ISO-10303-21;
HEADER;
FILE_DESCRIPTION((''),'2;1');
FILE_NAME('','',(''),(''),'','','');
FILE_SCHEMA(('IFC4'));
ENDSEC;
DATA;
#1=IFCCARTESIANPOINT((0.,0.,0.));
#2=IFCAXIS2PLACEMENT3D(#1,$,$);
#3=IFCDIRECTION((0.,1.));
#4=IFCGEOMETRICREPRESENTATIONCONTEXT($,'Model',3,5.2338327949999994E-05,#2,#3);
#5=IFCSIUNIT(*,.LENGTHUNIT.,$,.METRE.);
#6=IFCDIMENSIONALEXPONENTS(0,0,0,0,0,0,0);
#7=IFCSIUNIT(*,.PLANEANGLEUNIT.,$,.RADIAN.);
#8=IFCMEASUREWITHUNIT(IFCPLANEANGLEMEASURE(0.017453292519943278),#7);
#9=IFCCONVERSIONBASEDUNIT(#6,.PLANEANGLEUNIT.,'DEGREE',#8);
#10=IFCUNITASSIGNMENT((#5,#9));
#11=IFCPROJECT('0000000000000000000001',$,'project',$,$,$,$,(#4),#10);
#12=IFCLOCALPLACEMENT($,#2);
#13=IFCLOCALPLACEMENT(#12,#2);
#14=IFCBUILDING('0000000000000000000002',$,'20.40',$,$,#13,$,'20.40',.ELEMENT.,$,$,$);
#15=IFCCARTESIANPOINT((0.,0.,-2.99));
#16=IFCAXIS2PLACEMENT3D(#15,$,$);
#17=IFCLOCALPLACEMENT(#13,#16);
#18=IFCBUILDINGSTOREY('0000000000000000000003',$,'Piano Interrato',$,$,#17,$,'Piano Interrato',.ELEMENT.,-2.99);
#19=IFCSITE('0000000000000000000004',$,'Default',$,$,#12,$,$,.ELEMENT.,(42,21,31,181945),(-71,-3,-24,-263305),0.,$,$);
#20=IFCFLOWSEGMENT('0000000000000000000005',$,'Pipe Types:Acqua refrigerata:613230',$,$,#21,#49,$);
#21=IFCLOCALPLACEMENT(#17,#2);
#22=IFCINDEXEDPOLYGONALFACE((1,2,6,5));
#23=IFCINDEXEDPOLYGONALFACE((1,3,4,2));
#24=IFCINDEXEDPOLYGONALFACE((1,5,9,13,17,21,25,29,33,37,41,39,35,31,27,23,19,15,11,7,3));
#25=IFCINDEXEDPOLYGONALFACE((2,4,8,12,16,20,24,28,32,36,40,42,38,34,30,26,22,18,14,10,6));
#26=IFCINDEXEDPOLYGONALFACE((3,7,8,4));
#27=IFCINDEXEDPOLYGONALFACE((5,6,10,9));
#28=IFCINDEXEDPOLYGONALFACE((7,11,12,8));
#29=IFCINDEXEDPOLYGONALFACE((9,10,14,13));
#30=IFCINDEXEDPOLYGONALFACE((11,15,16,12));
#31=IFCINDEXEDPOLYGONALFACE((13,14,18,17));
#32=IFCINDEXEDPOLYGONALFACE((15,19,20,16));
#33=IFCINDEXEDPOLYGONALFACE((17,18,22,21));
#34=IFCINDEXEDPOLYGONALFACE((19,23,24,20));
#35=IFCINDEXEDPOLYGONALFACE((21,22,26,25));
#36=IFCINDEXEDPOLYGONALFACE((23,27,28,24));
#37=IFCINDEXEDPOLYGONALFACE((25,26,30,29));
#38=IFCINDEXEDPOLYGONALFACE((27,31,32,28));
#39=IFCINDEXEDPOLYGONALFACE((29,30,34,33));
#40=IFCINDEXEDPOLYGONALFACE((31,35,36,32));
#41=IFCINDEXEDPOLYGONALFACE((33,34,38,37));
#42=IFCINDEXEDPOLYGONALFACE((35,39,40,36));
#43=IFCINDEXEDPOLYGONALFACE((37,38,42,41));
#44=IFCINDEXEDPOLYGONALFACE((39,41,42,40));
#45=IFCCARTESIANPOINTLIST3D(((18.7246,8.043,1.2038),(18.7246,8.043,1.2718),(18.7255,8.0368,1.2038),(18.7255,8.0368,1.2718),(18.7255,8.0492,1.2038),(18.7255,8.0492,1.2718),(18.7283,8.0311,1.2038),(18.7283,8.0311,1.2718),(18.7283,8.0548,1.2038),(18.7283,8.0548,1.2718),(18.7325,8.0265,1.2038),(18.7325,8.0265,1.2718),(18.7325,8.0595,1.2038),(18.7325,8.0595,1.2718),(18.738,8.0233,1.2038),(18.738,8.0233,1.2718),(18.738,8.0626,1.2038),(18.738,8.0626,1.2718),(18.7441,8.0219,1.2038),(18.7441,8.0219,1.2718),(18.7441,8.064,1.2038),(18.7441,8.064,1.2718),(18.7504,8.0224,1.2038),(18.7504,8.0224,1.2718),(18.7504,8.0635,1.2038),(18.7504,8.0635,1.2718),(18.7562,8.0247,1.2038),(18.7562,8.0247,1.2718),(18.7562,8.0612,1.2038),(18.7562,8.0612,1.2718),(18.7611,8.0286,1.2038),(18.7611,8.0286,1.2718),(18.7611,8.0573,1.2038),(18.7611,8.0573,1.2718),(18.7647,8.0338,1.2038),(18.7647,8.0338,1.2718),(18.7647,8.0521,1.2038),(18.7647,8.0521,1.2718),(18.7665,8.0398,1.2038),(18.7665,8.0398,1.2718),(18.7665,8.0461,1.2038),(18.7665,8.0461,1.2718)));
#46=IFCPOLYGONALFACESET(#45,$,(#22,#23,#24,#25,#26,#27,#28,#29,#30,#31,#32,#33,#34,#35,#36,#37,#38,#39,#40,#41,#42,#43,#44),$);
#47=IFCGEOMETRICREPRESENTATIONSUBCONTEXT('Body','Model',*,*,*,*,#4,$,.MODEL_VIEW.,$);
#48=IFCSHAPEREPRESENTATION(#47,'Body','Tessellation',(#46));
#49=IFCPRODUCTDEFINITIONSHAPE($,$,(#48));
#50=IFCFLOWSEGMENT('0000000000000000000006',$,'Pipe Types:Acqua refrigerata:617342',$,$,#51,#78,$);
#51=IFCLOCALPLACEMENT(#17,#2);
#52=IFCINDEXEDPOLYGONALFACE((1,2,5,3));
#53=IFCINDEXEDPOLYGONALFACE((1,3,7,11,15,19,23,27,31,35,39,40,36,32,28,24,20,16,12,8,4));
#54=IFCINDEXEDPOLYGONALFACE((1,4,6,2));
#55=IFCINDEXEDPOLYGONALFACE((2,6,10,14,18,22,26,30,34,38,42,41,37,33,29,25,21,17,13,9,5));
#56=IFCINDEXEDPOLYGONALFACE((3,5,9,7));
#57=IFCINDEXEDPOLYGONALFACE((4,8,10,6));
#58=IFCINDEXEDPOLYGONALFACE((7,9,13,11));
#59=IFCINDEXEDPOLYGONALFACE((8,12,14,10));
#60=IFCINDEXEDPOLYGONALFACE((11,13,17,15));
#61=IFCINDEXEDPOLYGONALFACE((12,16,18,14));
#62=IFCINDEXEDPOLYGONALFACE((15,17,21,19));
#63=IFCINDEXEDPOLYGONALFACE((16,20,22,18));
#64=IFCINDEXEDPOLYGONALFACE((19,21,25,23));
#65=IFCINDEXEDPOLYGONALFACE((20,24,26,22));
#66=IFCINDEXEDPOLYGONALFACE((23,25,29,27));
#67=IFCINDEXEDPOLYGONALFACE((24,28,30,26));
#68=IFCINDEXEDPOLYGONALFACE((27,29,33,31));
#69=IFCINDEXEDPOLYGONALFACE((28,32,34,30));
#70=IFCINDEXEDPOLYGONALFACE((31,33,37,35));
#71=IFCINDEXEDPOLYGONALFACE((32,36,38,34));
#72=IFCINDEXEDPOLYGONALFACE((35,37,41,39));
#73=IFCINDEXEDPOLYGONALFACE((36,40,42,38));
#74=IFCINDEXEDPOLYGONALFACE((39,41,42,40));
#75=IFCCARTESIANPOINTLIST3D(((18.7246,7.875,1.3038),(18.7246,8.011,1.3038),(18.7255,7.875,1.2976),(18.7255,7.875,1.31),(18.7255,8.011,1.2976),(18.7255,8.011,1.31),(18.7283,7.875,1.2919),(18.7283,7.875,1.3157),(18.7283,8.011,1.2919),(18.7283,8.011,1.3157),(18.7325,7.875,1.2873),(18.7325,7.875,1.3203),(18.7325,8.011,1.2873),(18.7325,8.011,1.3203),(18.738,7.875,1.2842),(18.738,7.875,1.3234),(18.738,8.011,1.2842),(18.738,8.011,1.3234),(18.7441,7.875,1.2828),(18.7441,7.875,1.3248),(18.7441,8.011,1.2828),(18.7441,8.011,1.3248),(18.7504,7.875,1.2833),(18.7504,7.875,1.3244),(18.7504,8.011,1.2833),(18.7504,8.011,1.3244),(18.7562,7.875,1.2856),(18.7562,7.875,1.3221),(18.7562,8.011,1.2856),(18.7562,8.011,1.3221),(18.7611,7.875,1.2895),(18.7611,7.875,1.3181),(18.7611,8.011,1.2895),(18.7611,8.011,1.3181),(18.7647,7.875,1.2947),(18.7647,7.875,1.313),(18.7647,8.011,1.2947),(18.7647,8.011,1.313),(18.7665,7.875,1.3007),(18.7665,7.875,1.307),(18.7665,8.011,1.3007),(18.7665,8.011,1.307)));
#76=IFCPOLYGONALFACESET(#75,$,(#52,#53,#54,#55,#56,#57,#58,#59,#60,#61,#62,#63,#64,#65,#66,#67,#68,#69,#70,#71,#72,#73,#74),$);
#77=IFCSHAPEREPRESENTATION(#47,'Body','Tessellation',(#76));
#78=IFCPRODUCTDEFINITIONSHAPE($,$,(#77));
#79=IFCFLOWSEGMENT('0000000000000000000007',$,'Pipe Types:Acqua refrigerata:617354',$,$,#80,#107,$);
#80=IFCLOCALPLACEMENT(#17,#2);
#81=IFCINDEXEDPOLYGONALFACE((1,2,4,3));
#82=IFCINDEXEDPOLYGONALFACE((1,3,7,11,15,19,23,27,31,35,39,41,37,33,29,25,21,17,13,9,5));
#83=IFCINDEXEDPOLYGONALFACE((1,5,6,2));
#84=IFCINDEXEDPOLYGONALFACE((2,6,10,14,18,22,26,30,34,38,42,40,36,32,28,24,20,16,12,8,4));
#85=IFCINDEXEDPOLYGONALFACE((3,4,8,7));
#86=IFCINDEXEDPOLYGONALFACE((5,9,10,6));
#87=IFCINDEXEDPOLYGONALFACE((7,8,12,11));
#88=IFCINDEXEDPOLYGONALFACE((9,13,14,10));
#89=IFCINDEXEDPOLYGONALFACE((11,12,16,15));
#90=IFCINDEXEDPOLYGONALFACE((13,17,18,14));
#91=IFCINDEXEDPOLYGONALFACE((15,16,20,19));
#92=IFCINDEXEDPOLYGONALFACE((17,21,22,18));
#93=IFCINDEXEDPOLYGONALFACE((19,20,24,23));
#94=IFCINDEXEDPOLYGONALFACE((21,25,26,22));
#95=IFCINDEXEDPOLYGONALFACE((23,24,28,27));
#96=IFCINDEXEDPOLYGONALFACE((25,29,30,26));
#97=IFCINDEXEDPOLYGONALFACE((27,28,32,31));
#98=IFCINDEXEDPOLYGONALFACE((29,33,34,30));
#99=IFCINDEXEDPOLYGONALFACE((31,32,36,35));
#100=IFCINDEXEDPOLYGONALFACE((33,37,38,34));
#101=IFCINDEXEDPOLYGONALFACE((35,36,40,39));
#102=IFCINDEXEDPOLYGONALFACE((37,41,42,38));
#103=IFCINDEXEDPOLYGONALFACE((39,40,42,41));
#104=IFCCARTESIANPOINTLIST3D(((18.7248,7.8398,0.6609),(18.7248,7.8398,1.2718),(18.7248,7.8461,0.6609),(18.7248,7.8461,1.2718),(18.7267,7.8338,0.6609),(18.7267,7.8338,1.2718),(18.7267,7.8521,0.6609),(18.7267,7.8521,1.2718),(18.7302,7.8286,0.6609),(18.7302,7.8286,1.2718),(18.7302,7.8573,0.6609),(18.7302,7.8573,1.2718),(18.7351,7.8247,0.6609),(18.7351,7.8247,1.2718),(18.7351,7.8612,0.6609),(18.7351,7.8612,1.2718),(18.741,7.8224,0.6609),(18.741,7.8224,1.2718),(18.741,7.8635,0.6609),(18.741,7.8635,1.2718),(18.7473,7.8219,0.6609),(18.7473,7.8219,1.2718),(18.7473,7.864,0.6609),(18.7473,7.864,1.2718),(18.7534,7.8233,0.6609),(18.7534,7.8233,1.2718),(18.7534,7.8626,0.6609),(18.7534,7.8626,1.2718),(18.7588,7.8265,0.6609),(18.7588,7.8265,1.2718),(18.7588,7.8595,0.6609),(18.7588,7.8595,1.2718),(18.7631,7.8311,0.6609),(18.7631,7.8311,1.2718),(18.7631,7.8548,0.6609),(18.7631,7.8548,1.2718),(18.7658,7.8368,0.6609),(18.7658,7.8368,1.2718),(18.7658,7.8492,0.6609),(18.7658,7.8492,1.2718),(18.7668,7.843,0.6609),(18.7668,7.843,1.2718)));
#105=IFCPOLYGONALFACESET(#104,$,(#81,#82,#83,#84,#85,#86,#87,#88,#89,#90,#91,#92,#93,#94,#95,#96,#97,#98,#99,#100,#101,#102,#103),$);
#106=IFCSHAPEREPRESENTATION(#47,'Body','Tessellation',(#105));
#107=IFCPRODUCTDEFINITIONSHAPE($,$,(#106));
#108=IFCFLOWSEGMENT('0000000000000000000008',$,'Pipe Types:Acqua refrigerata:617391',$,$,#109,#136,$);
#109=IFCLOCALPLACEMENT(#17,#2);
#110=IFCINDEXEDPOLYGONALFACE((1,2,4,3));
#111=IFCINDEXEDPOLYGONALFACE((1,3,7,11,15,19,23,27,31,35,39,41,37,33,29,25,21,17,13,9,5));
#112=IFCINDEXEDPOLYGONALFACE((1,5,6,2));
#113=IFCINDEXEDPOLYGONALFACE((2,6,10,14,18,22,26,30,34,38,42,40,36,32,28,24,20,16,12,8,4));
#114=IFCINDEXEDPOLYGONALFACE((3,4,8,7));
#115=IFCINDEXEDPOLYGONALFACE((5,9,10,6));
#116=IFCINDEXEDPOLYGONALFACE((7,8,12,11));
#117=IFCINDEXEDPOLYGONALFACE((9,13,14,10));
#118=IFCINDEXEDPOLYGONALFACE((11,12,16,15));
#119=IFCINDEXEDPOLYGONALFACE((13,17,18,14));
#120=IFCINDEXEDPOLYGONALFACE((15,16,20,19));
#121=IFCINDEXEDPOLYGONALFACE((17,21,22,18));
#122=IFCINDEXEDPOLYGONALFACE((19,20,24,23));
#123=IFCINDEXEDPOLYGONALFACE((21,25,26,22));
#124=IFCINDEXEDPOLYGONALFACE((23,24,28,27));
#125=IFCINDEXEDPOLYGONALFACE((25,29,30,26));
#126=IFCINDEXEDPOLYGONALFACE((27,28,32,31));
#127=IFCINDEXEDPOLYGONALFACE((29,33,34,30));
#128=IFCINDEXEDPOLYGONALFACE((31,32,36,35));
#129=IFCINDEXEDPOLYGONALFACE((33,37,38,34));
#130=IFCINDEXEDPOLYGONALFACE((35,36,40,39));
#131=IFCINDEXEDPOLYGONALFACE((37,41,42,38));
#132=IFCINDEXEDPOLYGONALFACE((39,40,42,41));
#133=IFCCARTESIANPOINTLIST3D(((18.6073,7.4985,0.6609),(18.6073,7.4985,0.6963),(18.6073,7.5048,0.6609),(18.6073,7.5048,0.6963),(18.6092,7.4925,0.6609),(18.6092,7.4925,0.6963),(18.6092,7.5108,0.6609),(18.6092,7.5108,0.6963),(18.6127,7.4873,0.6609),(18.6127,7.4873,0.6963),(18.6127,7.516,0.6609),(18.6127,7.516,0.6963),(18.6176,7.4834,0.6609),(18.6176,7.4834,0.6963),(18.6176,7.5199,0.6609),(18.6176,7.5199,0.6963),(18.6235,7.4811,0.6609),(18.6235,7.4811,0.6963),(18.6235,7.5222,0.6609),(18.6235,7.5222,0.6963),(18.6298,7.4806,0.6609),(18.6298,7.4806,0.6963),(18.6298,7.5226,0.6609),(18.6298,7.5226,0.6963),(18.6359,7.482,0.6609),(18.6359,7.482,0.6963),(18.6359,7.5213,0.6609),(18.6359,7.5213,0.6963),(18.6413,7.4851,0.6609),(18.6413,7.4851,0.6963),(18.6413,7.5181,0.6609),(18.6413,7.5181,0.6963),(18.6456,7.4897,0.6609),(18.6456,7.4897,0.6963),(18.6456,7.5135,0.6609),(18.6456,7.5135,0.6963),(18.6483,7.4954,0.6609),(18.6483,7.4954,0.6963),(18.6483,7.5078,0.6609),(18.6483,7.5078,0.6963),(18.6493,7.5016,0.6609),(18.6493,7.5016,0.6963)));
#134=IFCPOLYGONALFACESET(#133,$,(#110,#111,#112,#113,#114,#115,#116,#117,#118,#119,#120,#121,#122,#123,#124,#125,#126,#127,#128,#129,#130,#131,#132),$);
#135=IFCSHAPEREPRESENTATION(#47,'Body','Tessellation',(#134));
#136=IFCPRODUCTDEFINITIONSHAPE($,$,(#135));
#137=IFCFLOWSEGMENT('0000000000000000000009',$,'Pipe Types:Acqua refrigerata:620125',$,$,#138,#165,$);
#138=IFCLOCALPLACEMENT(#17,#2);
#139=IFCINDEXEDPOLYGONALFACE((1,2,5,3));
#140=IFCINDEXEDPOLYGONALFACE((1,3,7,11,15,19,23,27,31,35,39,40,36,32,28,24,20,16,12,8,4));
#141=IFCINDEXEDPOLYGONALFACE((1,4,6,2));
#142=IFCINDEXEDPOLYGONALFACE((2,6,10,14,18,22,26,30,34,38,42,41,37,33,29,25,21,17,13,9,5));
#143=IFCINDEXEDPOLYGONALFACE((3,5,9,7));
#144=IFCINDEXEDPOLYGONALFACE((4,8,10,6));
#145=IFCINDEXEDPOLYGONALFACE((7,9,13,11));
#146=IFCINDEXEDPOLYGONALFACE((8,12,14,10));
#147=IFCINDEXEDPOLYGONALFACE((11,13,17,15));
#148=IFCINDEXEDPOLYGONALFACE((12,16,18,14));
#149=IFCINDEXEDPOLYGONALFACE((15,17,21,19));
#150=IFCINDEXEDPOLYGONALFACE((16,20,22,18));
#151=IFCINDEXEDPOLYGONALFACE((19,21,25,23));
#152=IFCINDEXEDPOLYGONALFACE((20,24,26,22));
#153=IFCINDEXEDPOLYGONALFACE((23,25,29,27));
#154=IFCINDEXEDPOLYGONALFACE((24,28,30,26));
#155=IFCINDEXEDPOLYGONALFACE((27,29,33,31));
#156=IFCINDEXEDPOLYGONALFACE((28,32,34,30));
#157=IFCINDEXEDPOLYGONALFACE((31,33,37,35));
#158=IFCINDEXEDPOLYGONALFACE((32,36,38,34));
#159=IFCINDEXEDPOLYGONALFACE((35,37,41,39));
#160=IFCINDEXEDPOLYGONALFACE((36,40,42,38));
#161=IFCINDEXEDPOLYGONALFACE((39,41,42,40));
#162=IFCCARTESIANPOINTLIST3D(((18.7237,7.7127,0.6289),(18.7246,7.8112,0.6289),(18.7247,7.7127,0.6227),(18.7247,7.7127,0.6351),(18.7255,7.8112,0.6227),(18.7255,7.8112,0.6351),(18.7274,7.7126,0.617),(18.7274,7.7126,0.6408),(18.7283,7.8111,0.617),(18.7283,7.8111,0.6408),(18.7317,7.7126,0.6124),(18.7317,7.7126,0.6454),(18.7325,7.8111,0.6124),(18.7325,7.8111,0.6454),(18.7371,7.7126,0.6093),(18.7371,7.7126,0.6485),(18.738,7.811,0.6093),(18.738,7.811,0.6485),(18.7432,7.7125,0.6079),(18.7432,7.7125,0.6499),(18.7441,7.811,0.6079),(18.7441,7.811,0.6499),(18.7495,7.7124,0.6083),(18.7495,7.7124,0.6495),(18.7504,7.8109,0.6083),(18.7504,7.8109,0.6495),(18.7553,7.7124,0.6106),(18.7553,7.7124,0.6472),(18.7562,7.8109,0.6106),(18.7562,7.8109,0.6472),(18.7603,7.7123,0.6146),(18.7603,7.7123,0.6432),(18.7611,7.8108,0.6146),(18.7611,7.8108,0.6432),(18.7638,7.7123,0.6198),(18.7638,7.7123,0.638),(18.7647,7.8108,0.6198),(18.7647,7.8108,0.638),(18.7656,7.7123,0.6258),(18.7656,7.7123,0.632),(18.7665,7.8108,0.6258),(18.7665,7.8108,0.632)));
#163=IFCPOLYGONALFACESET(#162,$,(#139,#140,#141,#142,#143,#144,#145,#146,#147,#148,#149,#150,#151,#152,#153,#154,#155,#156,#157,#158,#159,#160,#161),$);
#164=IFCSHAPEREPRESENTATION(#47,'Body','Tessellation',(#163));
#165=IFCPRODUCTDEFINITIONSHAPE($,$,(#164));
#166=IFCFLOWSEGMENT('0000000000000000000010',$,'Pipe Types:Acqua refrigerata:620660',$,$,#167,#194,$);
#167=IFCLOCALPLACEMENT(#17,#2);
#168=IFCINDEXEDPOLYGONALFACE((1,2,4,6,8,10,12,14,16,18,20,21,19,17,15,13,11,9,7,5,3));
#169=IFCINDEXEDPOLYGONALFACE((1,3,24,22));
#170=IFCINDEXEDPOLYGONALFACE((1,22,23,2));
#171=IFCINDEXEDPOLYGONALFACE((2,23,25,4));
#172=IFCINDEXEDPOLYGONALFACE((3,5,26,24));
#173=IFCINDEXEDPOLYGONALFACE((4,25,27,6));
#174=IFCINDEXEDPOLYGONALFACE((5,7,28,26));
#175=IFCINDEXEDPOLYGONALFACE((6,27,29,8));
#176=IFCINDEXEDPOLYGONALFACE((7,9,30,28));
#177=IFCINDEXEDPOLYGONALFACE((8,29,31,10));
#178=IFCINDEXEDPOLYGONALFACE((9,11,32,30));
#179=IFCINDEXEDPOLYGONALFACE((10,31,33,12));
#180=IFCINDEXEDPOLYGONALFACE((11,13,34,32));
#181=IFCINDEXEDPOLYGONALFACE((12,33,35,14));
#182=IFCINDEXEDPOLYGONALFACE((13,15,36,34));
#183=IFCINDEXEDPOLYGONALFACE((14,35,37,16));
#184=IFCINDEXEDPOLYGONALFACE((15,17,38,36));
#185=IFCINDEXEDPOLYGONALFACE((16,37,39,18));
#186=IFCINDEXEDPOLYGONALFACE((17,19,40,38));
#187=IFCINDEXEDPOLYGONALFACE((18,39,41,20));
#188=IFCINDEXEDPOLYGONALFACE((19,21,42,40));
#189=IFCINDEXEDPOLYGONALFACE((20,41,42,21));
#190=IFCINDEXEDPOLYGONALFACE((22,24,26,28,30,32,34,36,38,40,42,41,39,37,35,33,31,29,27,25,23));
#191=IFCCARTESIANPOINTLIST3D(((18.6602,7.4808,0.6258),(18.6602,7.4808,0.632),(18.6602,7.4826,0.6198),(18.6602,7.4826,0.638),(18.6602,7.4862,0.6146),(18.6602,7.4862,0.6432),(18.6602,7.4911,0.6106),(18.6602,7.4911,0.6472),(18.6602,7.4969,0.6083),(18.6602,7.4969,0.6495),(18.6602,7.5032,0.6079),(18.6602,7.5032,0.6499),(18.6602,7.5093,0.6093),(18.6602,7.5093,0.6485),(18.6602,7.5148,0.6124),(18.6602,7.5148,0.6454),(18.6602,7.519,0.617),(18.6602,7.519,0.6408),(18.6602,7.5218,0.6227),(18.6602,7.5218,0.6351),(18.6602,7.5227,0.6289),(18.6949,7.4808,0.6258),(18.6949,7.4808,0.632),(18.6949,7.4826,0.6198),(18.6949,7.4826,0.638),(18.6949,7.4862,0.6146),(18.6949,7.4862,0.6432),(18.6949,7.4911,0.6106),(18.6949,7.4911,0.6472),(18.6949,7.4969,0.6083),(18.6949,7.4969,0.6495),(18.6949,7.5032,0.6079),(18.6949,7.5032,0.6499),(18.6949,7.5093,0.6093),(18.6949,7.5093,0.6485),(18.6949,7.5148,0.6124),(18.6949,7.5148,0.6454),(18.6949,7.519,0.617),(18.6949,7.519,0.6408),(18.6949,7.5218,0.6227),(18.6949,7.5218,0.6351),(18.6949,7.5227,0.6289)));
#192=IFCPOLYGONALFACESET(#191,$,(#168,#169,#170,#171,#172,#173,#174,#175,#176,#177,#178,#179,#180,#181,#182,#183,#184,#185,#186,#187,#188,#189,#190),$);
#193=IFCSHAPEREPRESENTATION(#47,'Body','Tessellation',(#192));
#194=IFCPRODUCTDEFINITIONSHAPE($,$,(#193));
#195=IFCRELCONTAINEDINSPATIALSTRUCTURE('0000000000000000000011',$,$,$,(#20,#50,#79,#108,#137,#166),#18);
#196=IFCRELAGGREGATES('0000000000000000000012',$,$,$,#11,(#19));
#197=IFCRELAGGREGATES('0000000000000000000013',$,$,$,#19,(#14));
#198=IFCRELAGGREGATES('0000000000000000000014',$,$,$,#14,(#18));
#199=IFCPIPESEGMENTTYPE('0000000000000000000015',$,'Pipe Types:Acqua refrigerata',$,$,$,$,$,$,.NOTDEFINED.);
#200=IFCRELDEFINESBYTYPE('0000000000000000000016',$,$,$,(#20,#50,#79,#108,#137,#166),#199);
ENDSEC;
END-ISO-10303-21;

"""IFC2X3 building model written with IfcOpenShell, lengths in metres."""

from ifc_helpers import new_model, entity, si_unit, converted_unit, direction, frame, frame_2d, origin, origin_2d_with_axis, place, context, subcontext, project, spatial, circle, extrude, type_object, element, save


model = new_model("IFC2X3")

# Units and contexts
model_context = context("Model", 3, precision=5.2338327949999994e-05, world=origin(), true_north=direction((0.0, 1.0)))
body_context = subcontext(model_context, "Body", "Model", "MODEL_VIEW")
ifc_project = project(units=[si_unit("LENGTHUNIT", "METRE"), converted_unit("PLANEANGLEUNIT", "DEGREE", entity("IfcPlaneAngleMeasure", 0.017453292519943278), si_unit("PLANEANGLEUNIT", "RADIAN"), dimensions=[0, 0, 0, 0, 0, 0, 0])], contexts=[model_context])

# Site, building, storey
site_placement = place(None, origin())
site = spatial("IfcSite", under=ifc_project, at=site_placement, Name="Default", CompositionType="ELEMENT", RefLatitude=(42, 21, 31, 181945), RefLongitude=(-71, -3, -24, -263305), RefElevation=0.0)
building_placement = place(site_placement, origin())
building = spatial("IfcBuilding", under=site, at=building_placement, Name="20.40", LongName="20.40", CompositionType="ELEMENT")
storey_placement = place(building_placement, frame((0.0, 0.0, -2.99)))
storey = spatial("IfcBuildingStorey", under=building, at=storey_placement, Name="Piano Interrato", LongName="Piano Interrato", CompositionType="ELEMENT", Elevation=-2.99)

# Flow segments
pipe_segment_type_1 = type_object("IfcPipeSegmentType", Name="Pipe Types:Acqua refrigerata", PredefinedType="NOTDEFINED")
flow_segment_1_placement = place(storey_placement, origin())
element("IfcFlowSegment", 1, at=flow_segment_1_placement, inside=storey, type_object=pipe_segment_type_1, Name="Pipe Types:Acqua refrigerata:613230", context=body_context, shape_type="SweptSolid", body=[
    extrude(circle(Radius=0.0211, at=frame_2d((0.0, 0.0), x_axis=(1.0, 0.0))), frame((18.7457, 8.043, 1.2038), z_axis=(0.0, 0.0, 1.0), x_axis=(-1.0, 0.0, 0.0)), (0.0, 0.0, 1.0), 0.068),
])
flow_segment_2_placement = place(storey_placement, origin())
element("IfcFlowSegment", 2, at=flow_segment_2_placement, inside=storey, type_object=pipe_segment_type_1, Name="Pipe Types:Acqua refrigerata:617342", context=body_context, shape_type="SweptSolid", body=[
    extrude(circle(Radius=0.0211, at=frame_2d((0.0, 0.0), x_axis=(1.0, 0.0))), frame((18.7457, 7.875, 1.3038), z_axis=(0.0, 1.0, 0.0), x_axis=(-1.0, 0.0, 0.0)), (0.0, 0.0, 1.0), 0.136),
])
flow_segment_3_placement = place(storey_placement, origin())
element("IfcFlowSegment", 3, at=flow_segment_3_placement, inside=storey, type_object=pipe_segment_type_1, Name="Pipe Types:Acqua refrigerata:617354", context=body_context, shape_type="SweptSolid", body=[
    extrude(circle(Radius=0.0211, at=origin_2d_with_axis()), frame((18.7457, 7.843, 0.6609)), (0.0, 0.0, 1.0), 0.6109),
])
flow_segment_4_placement = place(storey_placement, origin())
element("IfcFlowSegment", 4, at=flow_segment_4_placement, inside=storey, type_object=pipe_segment_type_1, Name="Pipe Types:Acqua refrigerata:617391", context=body_context, shape_type="SweptSolid", body=[
    extrude(circle(Radius=0.0211, at=origin_2d_with_axis()), frame((18.6282, 7.5016, 0.6609)), (0.0, 0.0, 1.0), 0.0354),
])
flow_segment_5_placement = place(storey_placement, origin())
element("IfcFlowSegment", 5, at=flow_segment_5_placement, inside=storey, type_object=pipe_segment_type_1, Name="Pipe Types:Acqua refrigerata:620125", context=body_context, shape_type="SweptSolid", body=[
    extrude(circle(Radius=0.0211, at=frame_2d((0.0, 0.0), x_axis=(1.0, 0.0))), frame((18.7448, 7.7125, 0.6289), z_axis=(0.009014, 0.999959, 0.0), x_axis=(-0.999959, 0.009014, 0.0)), (0.0, 0.0, 1.0), 0.0985),
])
flow_segment_6_placement = place(storey_placement, origin())
element("IfcFlowSegment", 6, at=flow_segment_6_placement, inside=storey, type_object=pipe_segment_type_1, Name="Pipe Types:Acqua refrigerata:620660", context=body_context, shape_type="SweptSolid", body=[
    extrude(circle(Radius=0.0211, at=frame_2d((0.0, 0.0), x_axis=(1.0, 0.0))), frame((18.6602, 7.5016, 0.6289), z_axis=(1.0, 0.0, 0.0), x_axis=(0.0, 1.0, 0.0)), (0.0, 0.0, 1.0), 0.0347),
])

save(model, "model.ifc")
